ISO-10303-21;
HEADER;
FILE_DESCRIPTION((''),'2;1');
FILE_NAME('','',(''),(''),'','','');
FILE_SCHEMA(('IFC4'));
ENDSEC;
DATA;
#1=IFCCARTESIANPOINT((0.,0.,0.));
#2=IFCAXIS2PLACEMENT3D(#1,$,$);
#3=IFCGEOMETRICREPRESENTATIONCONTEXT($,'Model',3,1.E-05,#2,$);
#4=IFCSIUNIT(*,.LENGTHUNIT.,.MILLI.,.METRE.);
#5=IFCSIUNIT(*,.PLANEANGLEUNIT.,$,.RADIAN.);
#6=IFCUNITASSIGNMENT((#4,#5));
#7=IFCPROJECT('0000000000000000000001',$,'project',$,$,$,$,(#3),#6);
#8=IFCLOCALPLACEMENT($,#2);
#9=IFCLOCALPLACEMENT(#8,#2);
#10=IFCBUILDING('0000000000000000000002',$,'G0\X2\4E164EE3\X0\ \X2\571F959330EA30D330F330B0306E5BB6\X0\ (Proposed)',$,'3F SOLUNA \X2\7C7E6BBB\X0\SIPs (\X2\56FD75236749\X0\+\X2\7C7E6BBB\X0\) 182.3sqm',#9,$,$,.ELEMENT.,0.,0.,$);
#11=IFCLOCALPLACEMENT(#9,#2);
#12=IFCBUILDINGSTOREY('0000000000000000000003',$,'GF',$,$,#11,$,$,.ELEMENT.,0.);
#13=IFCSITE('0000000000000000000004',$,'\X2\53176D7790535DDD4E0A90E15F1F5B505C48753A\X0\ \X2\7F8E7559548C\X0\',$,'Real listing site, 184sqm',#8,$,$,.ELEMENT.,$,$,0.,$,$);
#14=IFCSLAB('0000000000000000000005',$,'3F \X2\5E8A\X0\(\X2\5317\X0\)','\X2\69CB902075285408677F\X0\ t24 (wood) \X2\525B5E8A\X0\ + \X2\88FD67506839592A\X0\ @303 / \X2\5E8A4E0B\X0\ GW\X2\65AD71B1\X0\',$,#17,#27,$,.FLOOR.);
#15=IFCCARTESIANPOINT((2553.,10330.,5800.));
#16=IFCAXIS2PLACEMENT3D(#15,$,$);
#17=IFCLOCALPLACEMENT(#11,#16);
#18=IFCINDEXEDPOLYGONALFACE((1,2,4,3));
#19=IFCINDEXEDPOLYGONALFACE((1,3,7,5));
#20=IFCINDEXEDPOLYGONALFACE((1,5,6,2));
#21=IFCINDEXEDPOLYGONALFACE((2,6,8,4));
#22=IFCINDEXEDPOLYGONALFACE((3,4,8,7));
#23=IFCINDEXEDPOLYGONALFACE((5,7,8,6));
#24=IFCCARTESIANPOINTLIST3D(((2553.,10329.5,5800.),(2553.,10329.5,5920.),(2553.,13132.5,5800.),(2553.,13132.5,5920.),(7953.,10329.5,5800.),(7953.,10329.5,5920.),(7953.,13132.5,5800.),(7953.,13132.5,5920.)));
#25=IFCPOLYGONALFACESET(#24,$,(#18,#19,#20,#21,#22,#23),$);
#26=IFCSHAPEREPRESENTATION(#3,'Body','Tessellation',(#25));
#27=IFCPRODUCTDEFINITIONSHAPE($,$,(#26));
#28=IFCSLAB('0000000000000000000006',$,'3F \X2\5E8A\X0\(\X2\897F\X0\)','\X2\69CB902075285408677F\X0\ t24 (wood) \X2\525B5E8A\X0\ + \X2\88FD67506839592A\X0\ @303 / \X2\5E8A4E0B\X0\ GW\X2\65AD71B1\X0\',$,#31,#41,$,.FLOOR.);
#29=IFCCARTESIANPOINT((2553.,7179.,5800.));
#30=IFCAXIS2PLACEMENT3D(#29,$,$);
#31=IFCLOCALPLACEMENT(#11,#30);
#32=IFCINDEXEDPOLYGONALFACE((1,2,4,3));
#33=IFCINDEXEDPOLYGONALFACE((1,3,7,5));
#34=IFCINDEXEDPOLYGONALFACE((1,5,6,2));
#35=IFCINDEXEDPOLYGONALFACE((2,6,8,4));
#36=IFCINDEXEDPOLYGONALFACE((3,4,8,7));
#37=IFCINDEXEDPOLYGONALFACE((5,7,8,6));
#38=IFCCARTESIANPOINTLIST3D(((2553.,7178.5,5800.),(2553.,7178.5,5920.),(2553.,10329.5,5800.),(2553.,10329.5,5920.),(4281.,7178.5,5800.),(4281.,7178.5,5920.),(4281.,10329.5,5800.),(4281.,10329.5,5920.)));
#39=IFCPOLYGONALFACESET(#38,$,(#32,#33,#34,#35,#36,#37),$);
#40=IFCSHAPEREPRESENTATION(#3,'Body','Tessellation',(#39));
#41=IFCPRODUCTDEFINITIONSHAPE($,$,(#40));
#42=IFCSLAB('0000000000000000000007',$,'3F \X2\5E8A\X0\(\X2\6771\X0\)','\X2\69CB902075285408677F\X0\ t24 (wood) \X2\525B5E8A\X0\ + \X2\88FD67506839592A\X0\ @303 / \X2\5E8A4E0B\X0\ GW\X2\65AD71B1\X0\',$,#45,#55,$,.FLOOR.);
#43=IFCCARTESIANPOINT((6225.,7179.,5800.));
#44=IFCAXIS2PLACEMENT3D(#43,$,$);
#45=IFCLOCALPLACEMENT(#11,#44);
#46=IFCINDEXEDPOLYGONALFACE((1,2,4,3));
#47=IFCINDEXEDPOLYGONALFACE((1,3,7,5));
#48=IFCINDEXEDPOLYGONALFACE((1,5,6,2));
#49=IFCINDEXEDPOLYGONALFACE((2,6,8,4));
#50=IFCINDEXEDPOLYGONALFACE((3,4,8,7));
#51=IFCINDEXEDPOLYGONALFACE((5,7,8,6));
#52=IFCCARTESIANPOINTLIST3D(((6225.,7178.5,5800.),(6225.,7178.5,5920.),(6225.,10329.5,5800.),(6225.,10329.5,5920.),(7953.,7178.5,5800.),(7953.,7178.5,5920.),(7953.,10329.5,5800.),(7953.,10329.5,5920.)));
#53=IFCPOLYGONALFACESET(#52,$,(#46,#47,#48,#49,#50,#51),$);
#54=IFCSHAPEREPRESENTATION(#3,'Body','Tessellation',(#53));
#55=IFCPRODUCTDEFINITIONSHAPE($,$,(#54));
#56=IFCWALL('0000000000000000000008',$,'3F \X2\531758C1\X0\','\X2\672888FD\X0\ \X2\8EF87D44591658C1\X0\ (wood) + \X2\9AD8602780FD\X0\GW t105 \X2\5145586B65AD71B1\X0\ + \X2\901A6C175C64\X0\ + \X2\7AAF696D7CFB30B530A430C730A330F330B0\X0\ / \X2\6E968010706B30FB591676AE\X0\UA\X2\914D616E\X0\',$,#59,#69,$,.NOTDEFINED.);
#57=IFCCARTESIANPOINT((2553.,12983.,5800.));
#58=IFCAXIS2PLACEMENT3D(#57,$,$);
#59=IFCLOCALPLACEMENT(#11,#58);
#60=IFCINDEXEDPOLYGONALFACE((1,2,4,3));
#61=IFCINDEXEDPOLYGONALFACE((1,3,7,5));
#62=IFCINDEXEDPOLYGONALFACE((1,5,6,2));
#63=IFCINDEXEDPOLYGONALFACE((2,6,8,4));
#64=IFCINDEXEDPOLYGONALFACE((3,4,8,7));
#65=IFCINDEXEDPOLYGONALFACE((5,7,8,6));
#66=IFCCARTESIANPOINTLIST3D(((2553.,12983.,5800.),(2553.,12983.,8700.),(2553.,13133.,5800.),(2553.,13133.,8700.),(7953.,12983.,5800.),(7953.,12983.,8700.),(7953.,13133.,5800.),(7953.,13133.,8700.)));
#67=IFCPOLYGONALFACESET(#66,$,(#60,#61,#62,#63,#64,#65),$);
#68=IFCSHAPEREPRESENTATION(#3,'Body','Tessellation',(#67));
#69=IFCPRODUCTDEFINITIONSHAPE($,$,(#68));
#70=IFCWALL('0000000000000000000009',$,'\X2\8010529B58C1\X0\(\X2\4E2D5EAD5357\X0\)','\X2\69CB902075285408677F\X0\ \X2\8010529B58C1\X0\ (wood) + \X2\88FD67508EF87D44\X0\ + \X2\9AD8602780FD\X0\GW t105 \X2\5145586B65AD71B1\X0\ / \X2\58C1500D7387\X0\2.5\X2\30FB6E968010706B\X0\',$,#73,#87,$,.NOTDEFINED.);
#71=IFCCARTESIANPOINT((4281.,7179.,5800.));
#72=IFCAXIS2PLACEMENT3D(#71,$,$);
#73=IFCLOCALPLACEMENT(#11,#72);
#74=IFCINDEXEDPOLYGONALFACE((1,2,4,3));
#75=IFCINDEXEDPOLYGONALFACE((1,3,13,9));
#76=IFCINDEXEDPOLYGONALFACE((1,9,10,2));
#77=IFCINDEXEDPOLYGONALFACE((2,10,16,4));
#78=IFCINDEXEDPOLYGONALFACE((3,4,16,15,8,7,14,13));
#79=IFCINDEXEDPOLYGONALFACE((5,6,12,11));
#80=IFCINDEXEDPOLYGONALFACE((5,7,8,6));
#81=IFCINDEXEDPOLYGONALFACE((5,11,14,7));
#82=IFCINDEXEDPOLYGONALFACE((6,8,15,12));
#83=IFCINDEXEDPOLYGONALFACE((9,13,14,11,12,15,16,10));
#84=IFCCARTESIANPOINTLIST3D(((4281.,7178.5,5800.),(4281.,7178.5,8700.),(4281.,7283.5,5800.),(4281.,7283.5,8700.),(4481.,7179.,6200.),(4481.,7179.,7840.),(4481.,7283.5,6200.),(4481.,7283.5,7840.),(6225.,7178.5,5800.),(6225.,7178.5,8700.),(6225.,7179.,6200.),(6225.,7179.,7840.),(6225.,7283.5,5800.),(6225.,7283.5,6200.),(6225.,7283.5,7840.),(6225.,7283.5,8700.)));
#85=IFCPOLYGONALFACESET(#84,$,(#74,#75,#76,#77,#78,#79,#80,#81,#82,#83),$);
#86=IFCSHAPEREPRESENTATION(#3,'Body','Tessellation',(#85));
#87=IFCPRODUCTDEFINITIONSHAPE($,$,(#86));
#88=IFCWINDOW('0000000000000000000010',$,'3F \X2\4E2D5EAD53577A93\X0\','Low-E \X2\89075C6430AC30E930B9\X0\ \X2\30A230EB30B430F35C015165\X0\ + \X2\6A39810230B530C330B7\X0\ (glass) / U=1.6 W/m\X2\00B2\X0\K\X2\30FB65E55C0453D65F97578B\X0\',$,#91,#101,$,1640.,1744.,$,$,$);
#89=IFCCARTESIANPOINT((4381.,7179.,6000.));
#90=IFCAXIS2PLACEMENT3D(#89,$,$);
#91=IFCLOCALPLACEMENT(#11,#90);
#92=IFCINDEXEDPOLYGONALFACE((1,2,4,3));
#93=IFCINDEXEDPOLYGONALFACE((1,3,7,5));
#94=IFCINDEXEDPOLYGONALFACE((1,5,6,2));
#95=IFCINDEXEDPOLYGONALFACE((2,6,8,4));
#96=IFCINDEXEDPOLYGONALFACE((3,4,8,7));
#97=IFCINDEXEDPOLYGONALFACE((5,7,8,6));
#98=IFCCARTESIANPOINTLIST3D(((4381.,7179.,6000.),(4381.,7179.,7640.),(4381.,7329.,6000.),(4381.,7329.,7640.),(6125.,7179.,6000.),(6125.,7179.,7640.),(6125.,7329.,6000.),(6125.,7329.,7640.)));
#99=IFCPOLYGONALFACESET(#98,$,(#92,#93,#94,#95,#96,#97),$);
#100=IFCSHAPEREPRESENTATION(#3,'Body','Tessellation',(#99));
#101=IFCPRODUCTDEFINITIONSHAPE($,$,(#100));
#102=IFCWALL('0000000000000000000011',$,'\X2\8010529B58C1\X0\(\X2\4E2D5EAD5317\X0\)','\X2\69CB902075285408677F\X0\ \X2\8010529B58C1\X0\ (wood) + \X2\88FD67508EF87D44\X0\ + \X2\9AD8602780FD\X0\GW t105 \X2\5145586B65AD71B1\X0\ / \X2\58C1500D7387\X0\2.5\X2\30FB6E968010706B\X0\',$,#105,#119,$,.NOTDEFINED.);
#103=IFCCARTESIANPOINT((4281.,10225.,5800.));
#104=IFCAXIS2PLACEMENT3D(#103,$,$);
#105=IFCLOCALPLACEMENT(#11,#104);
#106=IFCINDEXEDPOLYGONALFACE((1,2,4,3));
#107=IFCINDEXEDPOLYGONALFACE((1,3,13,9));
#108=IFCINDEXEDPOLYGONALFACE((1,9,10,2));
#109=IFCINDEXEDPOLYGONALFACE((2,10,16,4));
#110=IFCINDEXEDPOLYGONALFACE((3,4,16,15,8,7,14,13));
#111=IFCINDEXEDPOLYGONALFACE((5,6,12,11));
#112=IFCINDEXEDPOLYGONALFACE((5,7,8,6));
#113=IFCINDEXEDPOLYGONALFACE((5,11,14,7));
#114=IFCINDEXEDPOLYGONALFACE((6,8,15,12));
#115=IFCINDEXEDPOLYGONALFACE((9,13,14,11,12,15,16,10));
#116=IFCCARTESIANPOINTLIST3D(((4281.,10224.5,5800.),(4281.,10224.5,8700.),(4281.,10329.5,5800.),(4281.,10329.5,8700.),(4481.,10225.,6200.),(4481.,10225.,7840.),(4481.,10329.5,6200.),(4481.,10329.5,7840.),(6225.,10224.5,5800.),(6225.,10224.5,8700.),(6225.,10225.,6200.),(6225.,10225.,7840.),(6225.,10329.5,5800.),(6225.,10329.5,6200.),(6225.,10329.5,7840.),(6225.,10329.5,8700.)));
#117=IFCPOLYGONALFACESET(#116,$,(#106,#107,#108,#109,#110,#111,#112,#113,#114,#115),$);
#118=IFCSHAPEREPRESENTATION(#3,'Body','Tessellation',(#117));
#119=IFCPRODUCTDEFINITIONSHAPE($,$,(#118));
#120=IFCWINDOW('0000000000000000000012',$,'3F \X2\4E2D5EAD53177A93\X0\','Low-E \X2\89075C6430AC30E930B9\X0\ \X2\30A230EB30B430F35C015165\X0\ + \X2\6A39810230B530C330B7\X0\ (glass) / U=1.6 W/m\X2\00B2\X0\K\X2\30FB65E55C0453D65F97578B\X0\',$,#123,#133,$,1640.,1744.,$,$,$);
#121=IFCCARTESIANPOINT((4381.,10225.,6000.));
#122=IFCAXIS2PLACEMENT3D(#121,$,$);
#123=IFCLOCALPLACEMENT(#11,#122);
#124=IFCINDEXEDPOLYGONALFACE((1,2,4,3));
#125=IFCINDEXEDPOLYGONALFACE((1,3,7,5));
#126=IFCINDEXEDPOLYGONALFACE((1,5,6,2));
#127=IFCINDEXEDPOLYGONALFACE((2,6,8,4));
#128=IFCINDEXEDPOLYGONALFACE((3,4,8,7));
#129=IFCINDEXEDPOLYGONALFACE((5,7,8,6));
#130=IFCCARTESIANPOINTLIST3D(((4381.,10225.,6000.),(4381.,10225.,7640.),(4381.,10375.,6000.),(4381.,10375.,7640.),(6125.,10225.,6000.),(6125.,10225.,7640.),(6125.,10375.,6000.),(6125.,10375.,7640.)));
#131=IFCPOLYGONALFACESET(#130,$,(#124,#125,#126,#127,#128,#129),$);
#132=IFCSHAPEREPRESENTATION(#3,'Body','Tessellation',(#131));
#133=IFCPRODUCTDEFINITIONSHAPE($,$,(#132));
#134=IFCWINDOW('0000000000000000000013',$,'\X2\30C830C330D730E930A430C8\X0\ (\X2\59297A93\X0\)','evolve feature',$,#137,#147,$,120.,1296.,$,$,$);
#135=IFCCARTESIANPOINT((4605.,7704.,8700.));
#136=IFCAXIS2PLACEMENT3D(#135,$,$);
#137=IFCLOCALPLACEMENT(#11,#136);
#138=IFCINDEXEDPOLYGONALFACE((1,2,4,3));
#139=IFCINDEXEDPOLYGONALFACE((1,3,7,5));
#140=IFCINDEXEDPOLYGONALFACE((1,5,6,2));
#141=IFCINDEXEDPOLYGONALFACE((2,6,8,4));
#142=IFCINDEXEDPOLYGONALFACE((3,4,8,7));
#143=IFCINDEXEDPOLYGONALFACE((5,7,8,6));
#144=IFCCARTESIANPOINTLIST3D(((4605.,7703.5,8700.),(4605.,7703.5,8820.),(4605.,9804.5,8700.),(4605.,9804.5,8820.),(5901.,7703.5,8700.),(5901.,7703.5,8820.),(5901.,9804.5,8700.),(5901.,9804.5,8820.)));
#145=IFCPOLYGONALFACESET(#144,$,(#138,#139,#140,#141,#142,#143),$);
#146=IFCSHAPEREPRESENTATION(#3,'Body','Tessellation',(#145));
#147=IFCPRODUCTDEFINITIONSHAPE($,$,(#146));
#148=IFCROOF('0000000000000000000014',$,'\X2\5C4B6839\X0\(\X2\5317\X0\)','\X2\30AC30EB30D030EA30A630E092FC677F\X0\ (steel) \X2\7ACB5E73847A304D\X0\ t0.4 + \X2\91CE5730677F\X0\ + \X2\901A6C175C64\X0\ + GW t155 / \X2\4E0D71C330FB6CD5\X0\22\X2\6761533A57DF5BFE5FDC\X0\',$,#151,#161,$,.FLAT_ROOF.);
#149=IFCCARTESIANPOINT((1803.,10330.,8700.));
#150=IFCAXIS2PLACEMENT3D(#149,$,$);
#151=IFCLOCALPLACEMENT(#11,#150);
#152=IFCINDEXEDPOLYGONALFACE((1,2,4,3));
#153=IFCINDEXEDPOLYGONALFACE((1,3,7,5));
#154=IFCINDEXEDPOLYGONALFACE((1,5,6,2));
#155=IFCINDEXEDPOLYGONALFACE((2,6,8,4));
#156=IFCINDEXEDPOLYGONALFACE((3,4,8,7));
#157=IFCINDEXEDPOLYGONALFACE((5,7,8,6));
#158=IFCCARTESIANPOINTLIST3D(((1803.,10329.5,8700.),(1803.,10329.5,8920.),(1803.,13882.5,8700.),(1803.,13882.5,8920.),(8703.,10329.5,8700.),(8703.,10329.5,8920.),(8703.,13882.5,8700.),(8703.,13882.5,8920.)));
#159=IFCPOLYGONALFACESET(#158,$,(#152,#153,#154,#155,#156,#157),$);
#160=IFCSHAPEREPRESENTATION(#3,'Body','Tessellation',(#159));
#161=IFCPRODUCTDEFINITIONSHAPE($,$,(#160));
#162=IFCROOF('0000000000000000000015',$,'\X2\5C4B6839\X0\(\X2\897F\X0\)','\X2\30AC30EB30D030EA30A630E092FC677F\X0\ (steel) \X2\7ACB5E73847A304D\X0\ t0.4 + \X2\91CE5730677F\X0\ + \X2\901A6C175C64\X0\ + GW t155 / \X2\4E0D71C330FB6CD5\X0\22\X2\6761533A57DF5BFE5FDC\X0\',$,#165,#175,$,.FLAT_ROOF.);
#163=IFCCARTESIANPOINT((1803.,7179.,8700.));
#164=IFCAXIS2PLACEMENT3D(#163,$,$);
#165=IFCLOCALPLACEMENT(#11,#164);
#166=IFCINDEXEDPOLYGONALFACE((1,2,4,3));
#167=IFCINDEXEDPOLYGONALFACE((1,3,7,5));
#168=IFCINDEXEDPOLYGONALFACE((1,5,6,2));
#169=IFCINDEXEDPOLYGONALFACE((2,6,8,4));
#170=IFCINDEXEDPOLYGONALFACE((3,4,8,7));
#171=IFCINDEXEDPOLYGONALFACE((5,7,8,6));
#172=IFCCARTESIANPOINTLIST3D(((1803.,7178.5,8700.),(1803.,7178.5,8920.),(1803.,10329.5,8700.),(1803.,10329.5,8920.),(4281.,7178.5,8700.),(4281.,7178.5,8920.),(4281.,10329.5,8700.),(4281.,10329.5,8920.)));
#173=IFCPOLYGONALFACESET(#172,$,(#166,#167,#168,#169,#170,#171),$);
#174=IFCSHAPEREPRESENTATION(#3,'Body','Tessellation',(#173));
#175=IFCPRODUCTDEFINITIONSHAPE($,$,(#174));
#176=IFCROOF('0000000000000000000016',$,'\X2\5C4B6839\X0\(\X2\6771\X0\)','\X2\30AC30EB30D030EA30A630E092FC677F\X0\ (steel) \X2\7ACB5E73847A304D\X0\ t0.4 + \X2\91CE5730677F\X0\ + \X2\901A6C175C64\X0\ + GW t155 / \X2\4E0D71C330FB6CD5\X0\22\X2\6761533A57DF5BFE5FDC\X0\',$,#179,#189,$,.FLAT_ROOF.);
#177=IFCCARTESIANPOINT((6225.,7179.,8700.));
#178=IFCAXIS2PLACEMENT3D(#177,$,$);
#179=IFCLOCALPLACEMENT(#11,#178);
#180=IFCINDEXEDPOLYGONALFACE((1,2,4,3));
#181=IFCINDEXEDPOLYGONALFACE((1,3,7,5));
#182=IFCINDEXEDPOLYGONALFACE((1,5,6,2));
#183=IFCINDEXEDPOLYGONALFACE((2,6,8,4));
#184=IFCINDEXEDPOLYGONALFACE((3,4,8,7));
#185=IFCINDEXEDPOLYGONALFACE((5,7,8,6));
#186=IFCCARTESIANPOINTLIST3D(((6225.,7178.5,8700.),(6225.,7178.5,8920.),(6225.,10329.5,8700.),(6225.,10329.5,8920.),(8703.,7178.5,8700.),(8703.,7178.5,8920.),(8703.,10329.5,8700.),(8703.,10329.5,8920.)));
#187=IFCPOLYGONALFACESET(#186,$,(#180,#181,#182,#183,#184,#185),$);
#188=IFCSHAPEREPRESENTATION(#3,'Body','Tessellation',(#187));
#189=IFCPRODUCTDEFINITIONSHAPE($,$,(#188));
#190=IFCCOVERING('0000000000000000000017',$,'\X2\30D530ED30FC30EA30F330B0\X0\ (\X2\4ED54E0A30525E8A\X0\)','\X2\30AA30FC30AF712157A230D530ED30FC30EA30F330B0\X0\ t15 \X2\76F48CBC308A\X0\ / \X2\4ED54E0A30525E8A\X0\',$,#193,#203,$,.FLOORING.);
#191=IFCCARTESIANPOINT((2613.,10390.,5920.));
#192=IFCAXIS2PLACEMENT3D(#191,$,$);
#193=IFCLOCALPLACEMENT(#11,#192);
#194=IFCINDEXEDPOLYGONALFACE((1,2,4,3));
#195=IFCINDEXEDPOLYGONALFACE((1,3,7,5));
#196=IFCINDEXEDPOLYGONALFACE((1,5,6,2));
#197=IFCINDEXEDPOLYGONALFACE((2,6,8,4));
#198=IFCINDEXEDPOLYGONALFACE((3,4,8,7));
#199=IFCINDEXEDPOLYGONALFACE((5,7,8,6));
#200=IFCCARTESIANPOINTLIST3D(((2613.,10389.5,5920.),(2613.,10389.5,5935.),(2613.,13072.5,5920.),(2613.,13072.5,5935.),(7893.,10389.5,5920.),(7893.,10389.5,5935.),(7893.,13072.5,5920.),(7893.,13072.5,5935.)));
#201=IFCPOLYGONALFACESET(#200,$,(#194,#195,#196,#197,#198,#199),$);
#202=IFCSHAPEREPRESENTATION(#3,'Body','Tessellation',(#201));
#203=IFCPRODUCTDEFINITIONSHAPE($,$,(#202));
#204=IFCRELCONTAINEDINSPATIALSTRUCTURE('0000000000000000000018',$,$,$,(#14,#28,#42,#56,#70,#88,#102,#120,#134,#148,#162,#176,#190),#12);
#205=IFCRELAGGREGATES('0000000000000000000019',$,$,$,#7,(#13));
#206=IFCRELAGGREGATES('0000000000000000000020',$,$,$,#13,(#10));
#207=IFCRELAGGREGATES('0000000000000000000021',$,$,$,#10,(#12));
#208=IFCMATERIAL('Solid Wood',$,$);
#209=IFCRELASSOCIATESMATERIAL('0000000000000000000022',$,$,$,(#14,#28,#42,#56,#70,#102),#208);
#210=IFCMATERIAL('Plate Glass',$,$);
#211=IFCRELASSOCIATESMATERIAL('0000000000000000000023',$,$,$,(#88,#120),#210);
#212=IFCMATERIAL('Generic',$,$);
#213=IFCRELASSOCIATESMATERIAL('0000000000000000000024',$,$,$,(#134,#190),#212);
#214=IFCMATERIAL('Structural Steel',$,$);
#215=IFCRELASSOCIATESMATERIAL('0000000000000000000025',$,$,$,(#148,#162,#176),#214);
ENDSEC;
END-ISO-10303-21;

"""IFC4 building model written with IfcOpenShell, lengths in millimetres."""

from ifc_helpers import new_model, si_unit, frame, frame_2d, origin, place, context, project, spatial, rectangle, extrude, material, element, fill, save


model = new_model("IFC4")

# Units and contexts
model_context = context("Model", 3, precision=1e-05, world=origin())
ifc_project = project(units=[si_unit("LENGTHUNIT", "METRE", prefix="MILLI"), si_unit("PLANEANGLEUNIT", "RADIAN")], contexts=[model_context])

# Site, building, storey
site_placement = place(None, origin())
site = spatial("IfcSite", under=ifc_project, at=site_placement, Name="北海道川上郡弟子屈町 美留和", ObjectType="Real listing site, 184sqm", CompositionType="ELEMENT", RefElevation=0.0)
building_placement = place(site_placement, origin())
building = spatial("IfcBuilding", under=site, at=building_placement, Name="G0世代 土間リビングの家 (Proposed)", ObjectType="3F SOLUNA 籾殻SIPs (国産杉+籾殻) 182.3sqm", CompositionType="ELEMENT", ElevationOfRefHeight=0.0, ElevationOfTerrain=0.0)
storey_placement = place(building_placement, origin())
storey = spatial("IfcBuildingStorey", under=building, at=storey_placement, Name="GF", CompositionType="ELEMENT", Elevation=0.0)

# Slabs
ifc_material_1 = material(Name="Solid Wood")
slab_1_placement = place(storey_placement, frame((2553.0, 10330.0, 5800.0)))
element("IfcSlab", 1, at=slab_1_placement, inside=storey, material=ifc_material_1, Name="3F 床(北)", Description="構造用合板 t24 (wood) 剛床 + 製材根太 @303 / 床下 GW断熱", PredefinedType="FLOOR", context=model_context, shape_type="SweptSolid", body=[
    extrude(rectangle(XDim=5400.0, YDim=2803.0, at=frame_2d((2700.0, 1401.0))), frame((2553.0, 10330.0, 5800.0)), (0.0, 0.0, 1.0), 120.0),
])
slab_2_placement = place(storey_placement, frame((2553.0, 7179.0, 5800.0)))
element("IfcSlab", 2, at=slab_2_placement, inside=storey, material=ifc_material_1, Name="3F 床(西)", Description="構造用合板 t24 (wood) 剛床 + 製材根太 @303 / 床下 GW断熱", PredefinedType="FLOOR", context=model_context, shape_type="SweptSolid", body=[
    extrude(rectangle(XDim=1728.0, YDim=3151.0, at=frame_2d((864.0, 1575.0))), frame((2553.0, 7179.0, 5800.0)), (0.0, 0.0, 1.0), 120.0),
])
slab_3_placement = place(storey_placement, frame((6225.0, 7179.0, 5800.0)))
element("IfcSlab", 3, at=slab_3_placement, inside=storey, material=ifc_material_1, Name="3F 床(東)", Description="構造用合板 t24 (wood) 剛床 + 製材根太 @303 / 床下 GW断熱", PredefinedType="FLOOR", context=model_context, shape_type="SweptSolid", body=[
    extrude(rectangle(XDim=1728.0, YDim=3151.0, at=frame_2d((864.0, 1575.0))), frame((6225.0, 7179.0, 5800.0)), (0.0, 0.0, 1.0), 120.0),
])

# Wall
wall_1_placement = place(storey_placement, frame((2553.0, 12983.0, 5800.0)))
element("IfcWall", 4, at=wall_1_placement, inside=storey, material=ifc_material_1, Name="3F 北壁", Description="木製 軸組外壁 (wood) + 高性能GW t105 充填断熱 + 通気層 + 窯業系サイディング / 準耐火・外皮UA配慮", PredefinedType="NOTDEFINED", context=model_context, shape_type="SweptSolid", body=[
    extrude(rectangle(XDim=5400.0, YDim=150.0, at=frame_2d((2700.0, 75.0))), frame((2553.0, 12983.0, 5800.0)), (0.0, 0.0, 1.0), 2900.0),
])

# Walls, openings, windows
wall_2_placement = place(storey_placement, frame((4281.0, 7179.0, 5800.0)))
wall_2 = element("IfcWall", 5, at=wall_2_placement, inside=storey, material=ifc_material_1, Name="耐力壁(中庭南)", Description="構造用合板 耐力壁 (wood) + 製材軸組 + 高性能GW t105 充填断熱 / 壁倍率2.5・準耐火", PredefinedType="NOTDEFINED", context=model_context, shape_type="SweptSolid", body=[
    extrude(rectangle(XDim=1944.0, YDim=105.0, at=frame_2d((972.0, 52.0))), frame((4281.0, 7179.0, 5800.0)), (0.0, 0.0, 1.0), 2900.0),
])
opening_1_placement = place(storey_placement, frame((4381.0, 7179.0, 6000.0)))
opening_1 = element("IfcOpeningElement", 6, at=opening_1_placement, cuts=wall_2, PredefinedType="NOTDEFINED", context=model_context, shape_type="SweptSolid", body=[
    extrude(rectangle(XDim=1744.0, YDim=150.0, at=frame_2d((872.0, 75.0))), frame((4381.0, 7179.0, 6000.0)), (0.0, 0.0, 1.0), 1640.0),
])
ifc_material_2 = material(Name="Plate Glass")
window_1_placement = place(storey_placement, frame((4381.0, 7179.0, 6000.0)))
window_1 = element("IfcWindow", 7, at=window_1_placement, inside=storey, material=ifc_material_2, Name="3F 中庭南窓", Description="Low-E 複層ガラス アルゴン封入 + 樹脂サッシ (glass) / U=1.6 W/m²K・日射取得型", OverallHeight=1640.0, OverallWidth=1744.0, context=model_context, shape_type="SweptSolid", body=[
    extrude(rectangle(XDim=1744.0, YDim=150.0, at=frame_2d((872.0, 75.0))), frame((4381.0, 7179.0, 6000.0)), (0.0, 0.0, 1.0), 1640.0),
])
fill(opening_1, window_1)
wall_3_placement = place(storey_placement, frame((4281.0, 10225.0, 5800.0)))
wall_3 = element("IfcWall", 8, at=wall_3_placement, inside=storey, material=ifc_material_1, Name="耐力壁(中庭北)", Description="構造用合板 耐力壁 (wood) + 製材軸組 + 高性能GW t105 充填断熱 / 壁倍率2.5・準耐火", PredefinedType="NOTDEFINED", context=model_context, shape_type="SweptSolid", body=[
    extrude(rectangle(XDim=1944.0, YDim=105.0, at=frame_2d((972.0, 52.0))), frame((4281.0, 10225.0, 5800.0)), (0.0, 0.0, 1.0), 2900.0),
])
opening_2_placement = place(storey_placement, frame((4381.0, 10225.0, 6000.0)))
opening_2 = element("IfcOpeningElement", 9, at=opening_2_placement, cuts=wall_3, PredefinedType="NOTDEFINED", context=model_context, shape_type="SweptSolid", body=[
    extrude(rectangle(XDim=1744.0, YDim=150.0, at=frame_2d((872.0, 75.0))), frame((4381.0, 10225.0, 6000.0)), (0.0, 0.0, 1.0), 1640.0),
])
window_2_placement = place(storey_placement, frame((4381.0, 10225.0, 6000.0)))
window_2 = element("IfcWindow", 10, at=window_2_placement, inside=storey, material=ifc_material_2, Name="3F 中庭北窓", Description="Low-E 複層ガラス アルゴン封入 + 樹脂サッシ (glass) / U=1.6 W/m²K・日射取得型", OverallHeight=1640.0, OverallWidth=1744.0, context=model_context, shape_type="SweptSolid", body=[
    extrude(rectangle(XDim=1744.0, YDim=150.0, at=frame_2d((872.0, 75.0))), frame((4381.0, 10225.0, 6000.0)), (0.0, 0.0, 1.0), 1640.0),
])
fill(opening_2, window_2)

# Window
ifc_material_3 = material(Name="Generic")
window_3_placement = place(storey_placement, frame((4605.0, 7704.0, 8700.0)))
element("IfcWindow", 11, at=window_3_placement, inside=storey, material=ifc_material_3, Name="トップライト (天窓)", Description="evolve feature", OverallHeight=120.0, OverallWidth=1296.0, context=model_context, shape_type="SweptSolid", body=[
    extrude(rectangle(XDim=1296.0, YDim=2101.0, at=frame_2d((648.0, 1050.0))), frame((4605.0, 7704.0, 8700.0)), (0.0, 0.0, 1.0), 120.0),
])

# Roofs
ifc_material_4 = material(Name="Structural Steel")
for number, where, name in (
    (12, (1803.0, 10330.0, 8700.0), "屋根(北)"),
):
    element("IfcRoof", number, at=place(storey_placement, frame(where)), inside=storey, material=ifc_material_4, Name=name, Description="ガルバリウム鋼板 (steel) 立平葺き t0.4 + 野地板 + 通気層 + GW t155 / 不燃・法22条区域対応", PredefinedType="FLAT_ROOF", context=model_context, shape_type="SweptSolid", body=[
        extrude(rectangle(XDim=6900.0, YDim=3553.0, at=frame_2d((3450.0, 1776.0))), frame((1803.0, 10330.0, 8700.0)), (0.0, 0.0, 1.0), 220.0),
    ])
roof_1_placement = place(storey_placement, frame((1803.0, 7179.0, 8700.0)))
element("IfcRoof", 13, at=roof_1_placement, inside=storey, material=ifc_material_4, Name="屋根(西)", Description="ガルバリウム鋼板 (steel) 立平葺き t0.4 + 野地板 + 通気層 + GW t155 / 不燃・法22条区域対応", PredefinedType="FLAT_ROOF", context=model_context, shape_type="SweptSolid", body=[
    extrude(rectangle(XDim=2478.0, YDim=3151.0, at=frame_2d((1239.0, 1575.0))), frame((1803.0, 7179.0, 8700.0)), (0.0, 0.0, 1.0), 220.0),
])
roof_2_placement = place(storey_placement, frame((6225.0, 7179.0, 8700.0)))
element("IfcRoof", 14, at=roof_2_placement, inside=storey, material=ifc_material_4, Name="屋根(東)", Description="ガルバリウム鋼板 (steel) 立平葺き t0.4 + 野地板 + 通気層 + GW t155 / 不燃・法22条区域対応", PredefinedType="FLAT_ROOF", context=model_context, shape_type="SweptSolid", body=[
    extrude(rectangle(XDim=2478.0, YDim=3151.0, at=frame_2d((1239.0, 1575.0))), frame((6225.0, 7179.0, 8700.0)), (0.0, 0.0, 1.0), 220.0),
])

# Covering
covering_1_placement = place(storey_placement, frame((2613.0, 10390.0, 5920.0)))
element("IfcCovering", 15, at=covering_1_placement, inside=storey, material=ifc_material_3, Name="フローリング (仕上げ床)", Description="オーク無垢フローリング t15 直貼り / 仕上げ床", PredefinedType="FLOORING", context=model_context, shape_type="SweptSolid", body=[
    extrude(rectangle(XDim=5280.0, YDim=2683.0, at=frame_2d((2640.0, 1341.0))), frame((2613.0, 10390.0, 5920.0)), (0.0, 0.0, 1.0), 15.0),
])

save(model, "model.ifc")
